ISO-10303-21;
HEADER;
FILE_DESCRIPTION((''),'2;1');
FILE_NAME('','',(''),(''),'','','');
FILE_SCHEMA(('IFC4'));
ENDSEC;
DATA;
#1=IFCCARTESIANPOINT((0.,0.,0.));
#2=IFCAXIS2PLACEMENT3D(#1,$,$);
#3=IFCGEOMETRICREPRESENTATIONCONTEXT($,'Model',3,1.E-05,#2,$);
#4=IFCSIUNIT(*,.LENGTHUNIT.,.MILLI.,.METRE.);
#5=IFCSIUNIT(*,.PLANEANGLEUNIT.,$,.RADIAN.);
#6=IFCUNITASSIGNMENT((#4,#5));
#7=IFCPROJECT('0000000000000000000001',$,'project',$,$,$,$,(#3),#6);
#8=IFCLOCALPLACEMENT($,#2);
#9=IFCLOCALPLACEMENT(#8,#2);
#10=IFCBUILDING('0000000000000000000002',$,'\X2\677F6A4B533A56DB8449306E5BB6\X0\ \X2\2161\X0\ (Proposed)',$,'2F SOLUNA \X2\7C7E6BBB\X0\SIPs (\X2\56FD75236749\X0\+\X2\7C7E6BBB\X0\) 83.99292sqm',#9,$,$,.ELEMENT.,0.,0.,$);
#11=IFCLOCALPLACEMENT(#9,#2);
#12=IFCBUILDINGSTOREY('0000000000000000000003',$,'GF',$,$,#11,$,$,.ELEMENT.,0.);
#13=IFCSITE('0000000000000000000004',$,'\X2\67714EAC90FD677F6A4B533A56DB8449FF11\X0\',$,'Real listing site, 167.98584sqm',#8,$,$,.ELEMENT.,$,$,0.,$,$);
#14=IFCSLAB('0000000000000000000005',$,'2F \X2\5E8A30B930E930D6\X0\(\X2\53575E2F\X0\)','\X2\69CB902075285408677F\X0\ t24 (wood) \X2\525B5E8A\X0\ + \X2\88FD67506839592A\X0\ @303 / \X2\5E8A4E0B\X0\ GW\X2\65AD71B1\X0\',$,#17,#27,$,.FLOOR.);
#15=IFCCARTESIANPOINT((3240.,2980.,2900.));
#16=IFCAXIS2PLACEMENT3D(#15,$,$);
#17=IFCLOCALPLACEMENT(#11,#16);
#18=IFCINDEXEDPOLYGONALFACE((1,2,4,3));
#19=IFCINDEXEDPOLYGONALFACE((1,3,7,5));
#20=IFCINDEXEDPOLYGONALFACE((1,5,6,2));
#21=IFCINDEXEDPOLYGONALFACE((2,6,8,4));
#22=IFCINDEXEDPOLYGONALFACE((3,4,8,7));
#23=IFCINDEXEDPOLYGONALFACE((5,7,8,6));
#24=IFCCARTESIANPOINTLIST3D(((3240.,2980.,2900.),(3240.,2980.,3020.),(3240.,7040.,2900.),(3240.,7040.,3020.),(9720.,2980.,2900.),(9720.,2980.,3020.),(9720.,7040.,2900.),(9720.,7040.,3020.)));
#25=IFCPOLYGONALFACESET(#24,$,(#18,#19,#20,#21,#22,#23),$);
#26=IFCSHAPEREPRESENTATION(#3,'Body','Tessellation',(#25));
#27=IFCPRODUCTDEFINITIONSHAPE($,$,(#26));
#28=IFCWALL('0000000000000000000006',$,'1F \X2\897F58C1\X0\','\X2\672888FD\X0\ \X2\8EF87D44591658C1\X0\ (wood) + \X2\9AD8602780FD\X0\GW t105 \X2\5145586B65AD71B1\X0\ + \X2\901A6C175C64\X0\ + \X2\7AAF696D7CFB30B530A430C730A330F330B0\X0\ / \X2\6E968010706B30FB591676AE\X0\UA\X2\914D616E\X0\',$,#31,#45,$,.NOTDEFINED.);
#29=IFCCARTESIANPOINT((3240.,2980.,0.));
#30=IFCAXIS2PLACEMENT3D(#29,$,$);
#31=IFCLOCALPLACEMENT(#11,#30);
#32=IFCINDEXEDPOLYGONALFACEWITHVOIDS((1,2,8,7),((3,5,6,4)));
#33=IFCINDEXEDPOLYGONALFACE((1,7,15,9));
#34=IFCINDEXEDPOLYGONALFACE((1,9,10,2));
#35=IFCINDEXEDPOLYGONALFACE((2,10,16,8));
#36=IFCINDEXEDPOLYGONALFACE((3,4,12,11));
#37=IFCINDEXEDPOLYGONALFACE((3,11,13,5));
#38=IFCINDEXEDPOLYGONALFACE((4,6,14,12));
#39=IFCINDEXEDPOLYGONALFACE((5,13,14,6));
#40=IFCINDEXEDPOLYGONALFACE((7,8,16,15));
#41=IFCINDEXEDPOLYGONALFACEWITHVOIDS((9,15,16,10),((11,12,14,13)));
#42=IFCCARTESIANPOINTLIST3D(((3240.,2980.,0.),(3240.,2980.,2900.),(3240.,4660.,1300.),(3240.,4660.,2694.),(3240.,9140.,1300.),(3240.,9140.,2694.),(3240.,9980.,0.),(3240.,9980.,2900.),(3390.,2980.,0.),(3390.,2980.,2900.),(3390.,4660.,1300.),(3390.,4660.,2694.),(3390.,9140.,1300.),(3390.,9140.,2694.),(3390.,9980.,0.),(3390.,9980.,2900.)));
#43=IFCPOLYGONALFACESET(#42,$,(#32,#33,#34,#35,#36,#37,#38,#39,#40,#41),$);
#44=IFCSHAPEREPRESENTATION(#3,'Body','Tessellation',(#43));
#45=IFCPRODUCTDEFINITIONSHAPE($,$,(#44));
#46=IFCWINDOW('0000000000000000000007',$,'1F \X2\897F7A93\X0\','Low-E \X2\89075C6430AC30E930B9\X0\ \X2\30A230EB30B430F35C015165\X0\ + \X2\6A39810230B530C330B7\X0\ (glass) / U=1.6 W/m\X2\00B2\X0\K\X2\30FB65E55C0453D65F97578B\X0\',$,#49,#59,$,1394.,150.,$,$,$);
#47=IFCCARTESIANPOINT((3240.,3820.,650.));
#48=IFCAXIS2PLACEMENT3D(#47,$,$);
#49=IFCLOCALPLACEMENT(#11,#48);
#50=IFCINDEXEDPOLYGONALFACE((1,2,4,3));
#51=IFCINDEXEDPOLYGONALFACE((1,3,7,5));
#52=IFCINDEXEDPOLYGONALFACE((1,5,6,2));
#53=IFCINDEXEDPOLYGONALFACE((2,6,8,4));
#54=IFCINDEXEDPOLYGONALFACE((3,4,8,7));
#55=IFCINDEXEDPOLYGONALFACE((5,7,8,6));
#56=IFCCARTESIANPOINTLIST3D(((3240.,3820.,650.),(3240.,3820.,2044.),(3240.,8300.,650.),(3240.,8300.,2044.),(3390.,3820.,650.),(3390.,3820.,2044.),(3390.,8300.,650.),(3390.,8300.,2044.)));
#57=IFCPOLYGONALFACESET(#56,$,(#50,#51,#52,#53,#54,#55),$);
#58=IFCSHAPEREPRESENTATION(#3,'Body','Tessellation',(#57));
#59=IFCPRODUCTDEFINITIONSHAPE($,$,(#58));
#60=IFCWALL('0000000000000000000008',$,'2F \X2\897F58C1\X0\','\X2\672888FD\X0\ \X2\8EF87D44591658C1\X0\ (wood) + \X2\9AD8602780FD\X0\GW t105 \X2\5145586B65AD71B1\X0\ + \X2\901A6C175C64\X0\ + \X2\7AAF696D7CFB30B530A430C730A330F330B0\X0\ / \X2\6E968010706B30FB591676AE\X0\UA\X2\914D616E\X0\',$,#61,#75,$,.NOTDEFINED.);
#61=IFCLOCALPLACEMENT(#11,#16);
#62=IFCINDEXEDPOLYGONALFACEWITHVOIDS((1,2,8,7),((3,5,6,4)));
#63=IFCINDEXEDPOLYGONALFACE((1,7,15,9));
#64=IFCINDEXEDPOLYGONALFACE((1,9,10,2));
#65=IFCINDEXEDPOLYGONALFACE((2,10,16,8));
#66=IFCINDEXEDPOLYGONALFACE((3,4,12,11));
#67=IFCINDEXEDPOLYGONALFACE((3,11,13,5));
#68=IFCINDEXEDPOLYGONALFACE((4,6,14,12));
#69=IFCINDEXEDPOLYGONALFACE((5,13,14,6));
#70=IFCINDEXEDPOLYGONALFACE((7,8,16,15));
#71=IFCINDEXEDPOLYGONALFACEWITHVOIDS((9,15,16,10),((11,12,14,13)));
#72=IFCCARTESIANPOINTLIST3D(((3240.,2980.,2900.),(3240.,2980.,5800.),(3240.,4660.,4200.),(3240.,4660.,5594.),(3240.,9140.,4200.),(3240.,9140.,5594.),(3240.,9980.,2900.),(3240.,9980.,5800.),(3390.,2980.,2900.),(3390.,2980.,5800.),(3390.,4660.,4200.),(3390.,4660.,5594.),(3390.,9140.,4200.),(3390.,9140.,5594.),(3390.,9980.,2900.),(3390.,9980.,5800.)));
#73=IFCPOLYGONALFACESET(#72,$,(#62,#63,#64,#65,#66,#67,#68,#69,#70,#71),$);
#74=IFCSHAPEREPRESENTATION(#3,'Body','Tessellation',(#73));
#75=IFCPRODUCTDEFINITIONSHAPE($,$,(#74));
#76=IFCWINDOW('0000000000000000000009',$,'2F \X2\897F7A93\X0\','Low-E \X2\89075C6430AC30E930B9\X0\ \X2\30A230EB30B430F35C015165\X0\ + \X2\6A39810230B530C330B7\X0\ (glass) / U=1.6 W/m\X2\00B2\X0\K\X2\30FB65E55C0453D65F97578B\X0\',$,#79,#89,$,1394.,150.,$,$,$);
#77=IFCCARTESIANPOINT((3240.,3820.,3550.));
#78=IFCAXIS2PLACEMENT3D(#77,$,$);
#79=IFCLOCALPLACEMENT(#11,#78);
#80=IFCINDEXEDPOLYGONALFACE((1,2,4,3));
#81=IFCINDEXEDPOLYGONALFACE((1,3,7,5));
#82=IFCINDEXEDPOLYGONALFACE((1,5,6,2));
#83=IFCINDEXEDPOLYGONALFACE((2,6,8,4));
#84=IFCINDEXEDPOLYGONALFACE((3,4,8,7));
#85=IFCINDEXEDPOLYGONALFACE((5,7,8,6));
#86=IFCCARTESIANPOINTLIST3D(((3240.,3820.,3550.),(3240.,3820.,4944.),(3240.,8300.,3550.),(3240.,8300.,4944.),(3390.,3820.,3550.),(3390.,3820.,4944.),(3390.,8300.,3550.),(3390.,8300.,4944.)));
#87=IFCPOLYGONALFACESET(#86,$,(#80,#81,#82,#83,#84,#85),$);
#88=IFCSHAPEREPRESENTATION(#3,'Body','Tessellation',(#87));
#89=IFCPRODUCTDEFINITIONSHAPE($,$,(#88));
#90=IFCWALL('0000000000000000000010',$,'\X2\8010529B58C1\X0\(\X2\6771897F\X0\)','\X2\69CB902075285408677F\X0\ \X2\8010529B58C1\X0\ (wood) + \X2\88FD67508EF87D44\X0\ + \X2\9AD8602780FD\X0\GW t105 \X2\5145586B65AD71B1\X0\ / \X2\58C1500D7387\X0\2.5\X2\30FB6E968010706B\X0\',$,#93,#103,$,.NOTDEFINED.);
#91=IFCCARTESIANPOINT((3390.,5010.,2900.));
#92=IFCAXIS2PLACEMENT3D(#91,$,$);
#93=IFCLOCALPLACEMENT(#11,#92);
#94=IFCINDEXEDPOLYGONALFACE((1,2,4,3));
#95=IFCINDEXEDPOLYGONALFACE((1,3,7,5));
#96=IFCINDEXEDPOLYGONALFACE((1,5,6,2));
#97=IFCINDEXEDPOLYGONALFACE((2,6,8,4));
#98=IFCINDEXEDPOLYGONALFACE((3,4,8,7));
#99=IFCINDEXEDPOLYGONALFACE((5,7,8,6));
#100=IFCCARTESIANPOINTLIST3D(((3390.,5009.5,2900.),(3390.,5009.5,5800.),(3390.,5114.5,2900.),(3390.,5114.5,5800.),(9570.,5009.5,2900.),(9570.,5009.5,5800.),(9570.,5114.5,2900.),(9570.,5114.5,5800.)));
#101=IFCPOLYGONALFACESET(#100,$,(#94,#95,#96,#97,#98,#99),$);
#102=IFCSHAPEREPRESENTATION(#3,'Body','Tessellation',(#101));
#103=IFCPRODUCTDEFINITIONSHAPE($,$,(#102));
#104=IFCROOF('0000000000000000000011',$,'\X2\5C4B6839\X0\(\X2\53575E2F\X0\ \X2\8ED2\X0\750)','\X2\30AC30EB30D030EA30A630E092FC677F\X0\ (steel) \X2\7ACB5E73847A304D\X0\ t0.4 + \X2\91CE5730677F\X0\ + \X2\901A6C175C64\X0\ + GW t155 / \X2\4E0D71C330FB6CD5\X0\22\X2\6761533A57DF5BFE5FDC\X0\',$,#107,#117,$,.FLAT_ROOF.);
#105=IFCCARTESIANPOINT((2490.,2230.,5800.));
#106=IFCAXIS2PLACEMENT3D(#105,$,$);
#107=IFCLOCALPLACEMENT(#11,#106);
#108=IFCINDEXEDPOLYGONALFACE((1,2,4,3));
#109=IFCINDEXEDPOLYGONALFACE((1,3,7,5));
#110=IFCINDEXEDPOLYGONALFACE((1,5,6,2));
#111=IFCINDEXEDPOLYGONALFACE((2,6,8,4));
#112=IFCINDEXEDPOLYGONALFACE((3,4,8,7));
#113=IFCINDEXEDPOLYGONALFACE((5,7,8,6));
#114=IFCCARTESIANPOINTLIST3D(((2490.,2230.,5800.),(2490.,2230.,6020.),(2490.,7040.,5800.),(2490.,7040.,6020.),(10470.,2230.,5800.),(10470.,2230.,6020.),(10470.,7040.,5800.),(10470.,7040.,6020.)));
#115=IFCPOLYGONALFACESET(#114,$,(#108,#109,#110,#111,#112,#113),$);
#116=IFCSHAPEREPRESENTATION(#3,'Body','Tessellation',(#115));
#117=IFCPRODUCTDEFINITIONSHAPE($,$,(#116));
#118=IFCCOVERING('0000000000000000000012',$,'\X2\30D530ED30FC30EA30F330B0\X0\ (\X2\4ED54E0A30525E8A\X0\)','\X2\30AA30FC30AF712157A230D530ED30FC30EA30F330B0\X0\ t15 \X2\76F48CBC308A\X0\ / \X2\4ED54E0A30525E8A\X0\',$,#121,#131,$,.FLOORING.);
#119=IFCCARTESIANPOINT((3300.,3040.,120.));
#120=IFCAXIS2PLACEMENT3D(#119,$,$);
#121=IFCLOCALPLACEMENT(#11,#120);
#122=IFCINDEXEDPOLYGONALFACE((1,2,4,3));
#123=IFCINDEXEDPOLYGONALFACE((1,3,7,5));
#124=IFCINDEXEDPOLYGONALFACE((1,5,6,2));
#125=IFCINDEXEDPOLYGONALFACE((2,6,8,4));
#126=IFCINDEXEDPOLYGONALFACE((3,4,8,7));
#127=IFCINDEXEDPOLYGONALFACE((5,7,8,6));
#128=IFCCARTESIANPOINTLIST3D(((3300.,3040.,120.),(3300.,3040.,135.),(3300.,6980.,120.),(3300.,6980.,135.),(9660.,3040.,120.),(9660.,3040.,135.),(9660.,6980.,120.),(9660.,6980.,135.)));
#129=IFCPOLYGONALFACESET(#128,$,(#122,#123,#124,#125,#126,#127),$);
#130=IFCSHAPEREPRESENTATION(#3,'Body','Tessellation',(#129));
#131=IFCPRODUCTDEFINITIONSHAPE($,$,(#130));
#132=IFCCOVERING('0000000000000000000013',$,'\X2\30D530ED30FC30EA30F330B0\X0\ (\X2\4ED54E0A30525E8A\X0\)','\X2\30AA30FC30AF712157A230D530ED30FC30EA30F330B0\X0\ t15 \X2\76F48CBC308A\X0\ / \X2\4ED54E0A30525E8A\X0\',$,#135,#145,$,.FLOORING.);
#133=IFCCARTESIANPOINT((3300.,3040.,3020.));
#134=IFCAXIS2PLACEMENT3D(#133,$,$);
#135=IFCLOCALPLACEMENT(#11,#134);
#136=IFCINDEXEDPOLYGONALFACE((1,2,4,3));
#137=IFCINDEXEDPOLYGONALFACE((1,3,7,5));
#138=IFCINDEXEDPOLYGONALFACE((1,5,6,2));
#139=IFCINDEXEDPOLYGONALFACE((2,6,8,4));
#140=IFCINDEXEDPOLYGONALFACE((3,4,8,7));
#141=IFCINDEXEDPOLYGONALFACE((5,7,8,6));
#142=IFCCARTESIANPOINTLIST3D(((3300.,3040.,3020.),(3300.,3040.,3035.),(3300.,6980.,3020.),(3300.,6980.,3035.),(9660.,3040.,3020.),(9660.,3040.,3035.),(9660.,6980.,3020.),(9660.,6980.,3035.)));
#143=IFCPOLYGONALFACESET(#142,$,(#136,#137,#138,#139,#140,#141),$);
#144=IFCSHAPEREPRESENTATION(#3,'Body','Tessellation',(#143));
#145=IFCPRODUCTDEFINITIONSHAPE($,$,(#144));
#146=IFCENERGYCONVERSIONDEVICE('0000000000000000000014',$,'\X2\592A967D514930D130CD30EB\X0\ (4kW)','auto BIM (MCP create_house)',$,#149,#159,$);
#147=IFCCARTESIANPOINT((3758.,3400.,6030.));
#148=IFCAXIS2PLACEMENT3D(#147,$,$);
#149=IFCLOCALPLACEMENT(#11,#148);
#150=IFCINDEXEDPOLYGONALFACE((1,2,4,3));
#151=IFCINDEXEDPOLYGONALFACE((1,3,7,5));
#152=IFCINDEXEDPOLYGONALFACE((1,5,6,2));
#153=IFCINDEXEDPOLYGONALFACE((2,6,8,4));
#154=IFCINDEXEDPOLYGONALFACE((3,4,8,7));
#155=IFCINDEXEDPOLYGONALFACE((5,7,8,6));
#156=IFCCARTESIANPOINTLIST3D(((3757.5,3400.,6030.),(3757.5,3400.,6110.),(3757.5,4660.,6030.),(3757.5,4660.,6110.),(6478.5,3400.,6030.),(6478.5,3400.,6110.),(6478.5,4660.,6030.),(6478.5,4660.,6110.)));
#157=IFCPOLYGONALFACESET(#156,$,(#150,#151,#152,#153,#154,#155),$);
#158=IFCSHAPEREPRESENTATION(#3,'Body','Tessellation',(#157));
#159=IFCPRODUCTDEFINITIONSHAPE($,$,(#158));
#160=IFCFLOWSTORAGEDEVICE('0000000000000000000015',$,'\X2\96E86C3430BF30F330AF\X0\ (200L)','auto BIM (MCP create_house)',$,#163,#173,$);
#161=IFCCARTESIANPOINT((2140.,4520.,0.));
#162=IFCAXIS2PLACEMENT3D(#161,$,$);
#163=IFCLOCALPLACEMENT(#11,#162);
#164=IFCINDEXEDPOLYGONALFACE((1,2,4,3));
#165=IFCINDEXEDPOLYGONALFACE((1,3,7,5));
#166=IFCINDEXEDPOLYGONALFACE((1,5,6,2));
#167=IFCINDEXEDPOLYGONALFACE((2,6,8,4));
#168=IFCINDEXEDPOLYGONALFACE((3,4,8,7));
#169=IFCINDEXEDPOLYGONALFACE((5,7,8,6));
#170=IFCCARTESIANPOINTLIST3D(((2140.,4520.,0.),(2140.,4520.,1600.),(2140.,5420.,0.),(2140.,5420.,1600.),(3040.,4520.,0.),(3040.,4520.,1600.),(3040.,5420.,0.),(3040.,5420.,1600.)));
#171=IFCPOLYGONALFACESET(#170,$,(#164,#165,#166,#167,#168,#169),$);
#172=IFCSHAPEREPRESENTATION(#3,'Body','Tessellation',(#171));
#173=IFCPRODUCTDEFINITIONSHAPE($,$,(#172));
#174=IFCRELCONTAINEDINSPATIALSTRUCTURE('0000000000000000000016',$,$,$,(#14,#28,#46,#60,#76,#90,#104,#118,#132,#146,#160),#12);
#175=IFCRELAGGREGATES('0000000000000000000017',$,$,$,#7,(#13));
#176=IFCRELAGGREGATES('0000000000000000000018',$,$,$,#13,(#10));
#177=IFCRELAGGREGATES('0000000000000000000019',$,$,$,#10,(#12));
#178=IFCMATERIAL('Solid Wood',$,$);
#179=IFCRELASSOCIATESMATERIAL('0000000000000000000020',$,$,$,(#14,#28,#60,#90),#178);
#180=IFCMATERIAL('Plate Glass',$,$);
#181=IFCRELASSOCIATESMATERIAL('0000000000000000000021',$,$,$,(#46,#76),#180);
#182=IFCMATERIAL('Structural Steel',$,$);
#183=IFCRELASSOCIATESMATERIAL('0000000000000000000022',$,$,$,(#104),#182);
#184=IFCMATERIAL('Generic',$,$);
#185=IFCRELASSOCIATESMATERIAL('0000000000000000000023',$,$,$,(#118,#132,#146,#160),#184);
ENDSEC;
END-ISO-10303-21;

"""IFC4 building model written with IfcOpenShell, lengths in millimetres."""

from ifc_helpers import new_model, si_unit, frame, frame_2d, origin, place, context, project, spatial, rectangle, extrude, material, element, fill, save


model = new_model("IFC4")

# Units and contexts
model_context = context("Model", 3, precision=1e-05, world=origin())
ifc_project = project(units=[si_unit("LENGTHUNIT", "METRE", prefix="MILLI"), si_unit("PLANEANGLEUNIT", "RADIAN")], contexts=[model_context])

# Site, building, storey
site_placement = place(None, origin())
site = spatial("IfcSite", under=ifc_project, at=site_placement, Name="東京都板橋区四葉１", ObjectType="Real listing site, 167.98584sqm", CompositionType="ELEMENT", RefElevation=0.0)
building_placement = place(site_placement, origin())
building = spatial("IfcBuilding", under=site, at=building_placement, Name="板橋区四葉の家 Ⅱ (Proposed)", ObjectType="2F SOLUNA 籾殻SIPs (国産杉+籾殻) 83.99292sqm", CompositionType="ELEMENT", ElevationOfRefHeight=0.0, ElevationOfTerrain=0.0)
storey_placement = place(building_placement, origin())
storey = spatial("IfcBuildingStorey", under=building, at=storey_placement, Name="GF", CompositionType="ELEMENT", Elevation=0.0)

# Slab
ifc_material_1 = material(Name="Solid Wood")
slab_1_placement = place(storey_placement, frame((3240.0, 2980.0, 2900.0)))
element("IfcSlab", 1, at=slab_1_placement, inside=storey, material=ifc_material_1, Name="2F 床スラブ(南帯)", Description="構造用合板 t24 (wood) 剛床 + 製材根太 @303 / 床下 GW断熱", PredefinedType="FLOOR", context=model_context, shape_type="SweptSolid", body=[
    extrude(rectangle(XDim=6480.0, YDim=4060.0, at=frame_2d((3240.0, 2030.0))), frame((3240.0, 2980.0, 2900.0)), (0.0, 0.0, 1.0), 120.0),
])

# Shared definitions
ifc_material_2 = material(Name="Plate Glass")

# Wall, opening, window
wall_1_placement = place(storey_placement, frame((3240.0, 2980.0, 0.0)))
wall_1 = element("IfcWall", 2, at=wall_1_placement, inside=storey, material=ifc_material_1, Name="1F 西壁", Description="木製 軸組外壁 (wood) + 高性能GW t105 充填断熱 + 通気層 + 窯業系サイディング / 準耐火・外皮UA配慮", PredefinedType="NOTDEFINED", context=model_context, shape_type="SweptSolid", body=[
    extrude(rectangle(XDim=150.0, YDim=7000.0, at=frame_2d((75.0, 3500.0))), frame((3240.0, 2980.0, 0.0)), (0.0, 0.0, 1.0), 2900.0),
])
opening_1_placement = place(storey_placement, frame((3240.0, 3820.0, 650.0)))
opening_1 = element("IfcOpeningElement", 3, at=opening_1_placement, cuts=wall_1, PredefinedType="NOTDEFINED", context=model_context, shape_type="SweptSolid", body=[
    extrude(rectangle(XDim=150.0, YDim=4480.0, at=frame_2d((75.0, 2240.0))), frame((3240.0, 3820.0, 650.0)), (0.0, 0.0, 1.0), 1394.0),
])
window_1_placement = place(storey_placement, frame((3240.0, 3820.0, 650.0)))
window_1 = element("IfcWindow", 4, at=window_1_placement, inside=storey, material=ifc_material_2, Name="1F 西窓", Description="Low-E 複層ガラス アルゴン封入 + 樹脂サッシ (glass) / U=1.6 W/m²K・日射取得型", OverallHeight=1394.0, OverallWidth=150.0, context=model_context, shape_type="SweptSolid", body=[
    extrude(rectangle(XDim=150.0, YDim=4480.0, at=frame_2d((75.0, 2240.0))), frame((3240.0, 3820.0, 650.0)), (0.0, 0.0, 1.0), 1394.0),
])
fill(opening_1, window_1)

# Wall, opening, window
wall_2_placement = place(storey_placement, frame((3240.0, 2980.0, 2900.0)))
wall_2 = element("IfcWall", 5, at=wall_2_placement, inside=storey, material=ifc_material_1, Name="2F 西壁", Description="木製 軸組外壁 (wood) + 高性能GW t105 充填断熱 + 通気層 + 窯業系サイディング / 準耐火・外皮UA配慮", PredefinedType="NOTDEFINED", context=model_context, shape_type="SweptSolid", body=[
    extrude(rectangle(XDim=150.0, YDim=7000.0, at=frame_2d((75.0, 3500.0))), frame((3240.0, 2980.0, 2900.0)), (0.0, 0.0, 1.0), 2900.0),
])
opening_2_placement = place(storey_placement, frame((3240.0, 3820.0, 3550.0)))
opening_2 = element("IfcOpeningElement", 6, at=opening_2_placement, cuts=wall_2, PredefinedType="NOTDEFINED", context=model_context, shape_type="SweptSolid", body=[
    extrude(rectangle(XDim=150.0, YDim=4480.0, at=frame_2d((75.0, 2240.0))), frame((3240.0, 3820.0, 3550.0)), (0.0, 0.0, 1.0), 1394.0),
])
window_2_placement = place(storey_placement, frame((3240.0, 3820.0, 3550.0)))
window_2 = element("IfcWindow", 7, at=window_2_placement, inside=storey, material=ifc_material_2, Name="2F 西窓", Description="Low-E 複層ガラス アルゴン封入 + 樹脂サッシ (glass) / U=1.6 W/m²K・日射取得型", OverallHeight=1394.0, OverallWidth=150.0, context=model_context, shape_type="SweptSolid", body=[
    extrude(rectangle(XDim=150.0, YDim=4480.0, at=frame_2d((75.0, 2240.0))), frame((3240.0, 3820.0, 3550.0)), (0.0, 0.0, 1.0), 1394.0),
])
fill(opening_2, window_2)

# Wall
wall_3_placement = place(storey_placement, frame((3390.0, 5010.0, 2900.0)))
element("IfcWall", 8, at=wall_3_placement, inside=storey, material=ifc_material_1, Name="耐力壁(東西)", Description="構造用合板 耐力壁 (wood) + 製材軸組 + 高性能GW t105 充填断熱 / 壁倍率2.5・準耐火", PredefinedType="NOTDEFINED", context=model_context, shape_type="SweptSolid", body=[
    extrude(rectangle(XDim=6180.0, YDim=105.0, at=frame_2d((3090.0, 52.0))), frame((3390.0, 5010.0, 2900.0)), (0.0, 0.0, 1.0), 2900.0),
])

# Roof
ifc_material_3 = material(Name="Structural Steel")
for number, where, name in (
    (9, (2490.0, 2230.0, 5800.0), "屋根(南帯 軒750)"),
):
    element("IfcRoof", number, at=place(storey_placement, frame(where)), inside=storey, material=ifc_material_3, Name=name, Description="ガルバリウム鋼板 (steel) 立平葺き t0.4 + 野地板 + 通気層 + GW t155 / 不燃・法22条区域対応", PredefinedType="FLAT_ROOF", context=model_context, shape_type="SweptSolid", body=[
        extrude(rectangle(XDim=7980.0, YDim=4810.0, at=frame_2d((3990.0, 2405.0))), frame((2490.0, 2230.0, 5800.0)), (0.0, 0.0, 1.0), 220.0),
    ])

# Coverings
ifc_material_4 = material(Name="Generic")
covering_1_placement = place(storey_placement, frame((3300.0, 3040.0, 120.0)))
element("IfcCovering", 10, at=covering_1_placement, inside=storey, material=ifc_material_4, Name="フローリング (仕上げ床)", Description="オーク無垢フローリング t15 直貼り / 仕上げ床", PredefinedType="FLOORING", context=model_context, shape_type="SweptSolid", body=[
    extrude(rectangle(XDim=6360.0, YDim=3940.0, at=frame_2d((3180.0, 1970.0))), frame((3300.0, 3040.0, 120.0)), (0.0, 0.0, 1.0), 15.0),
])
covering_2_placement = place(storey_placement, frame((3300.0, 3040.0, 3020.0)))
element("IfcCovering", 11, at=covering_2_placement, inside=storey, material=ifc_material_4, Name="フローリング (仕上げ床)", Description="オーク無垢フローリング t15 直貼り / 仕上げ床", PredefinedType="FLOORING", context=model_context, shape_type="SweptSolid", body=[
    extrude(rectangle(XDim=6360.0, YDim=3940.0, at=frame_2d((3180.0, 1970.0))), frame((3300.0, 3040.0, 3020.0)), (0.0, 0.0, 1.0), 15.0),
])

# Energy conversion device
energy_conversion_device_placement = place(storey_placement, frame((3758.0, 3400.0, 6030.0)))
element("IfcEnergyConversionDevice", 12, at=energy_conversion_device_placement, inside=storey, material=ifc_material_4, Name="太陽光パネル (4kW)", Description="auto BIM (MCP create_house)", context=model_context, shape_type="SweptSolid", body=[
    extrude(rectangle(XDim=2721.0, YDim=1260.0, at=frame_2d((1360.0, 630.0))), frame((3758.0, 3400.0, 6030.0)), (0.0, 0.0, 1.0), 80.0),
])

# Flow storage device
flow_storage_device_placement = place(storey_placement, frame((2140.0, 4520.0, 0.0)))
element("IfcFlowStorageDevice", 13, at=flow_storage_device_placement, inside=storey, material=ifc_material_4, Name="雨水タンク (200L)", Description="auto BIM (MCP create_house)", context=model_context, shape_type="SweptSolid", body=[
    extrude(rectangle(XDim=900.0, YDim=900.0, at=frame_2d((450.0, 450.0))), frame((2140.0, 4520.0, 0.0)), (0.0, 0.0, 1.0), 1600.0),
])

save(model, "model.ifc")
